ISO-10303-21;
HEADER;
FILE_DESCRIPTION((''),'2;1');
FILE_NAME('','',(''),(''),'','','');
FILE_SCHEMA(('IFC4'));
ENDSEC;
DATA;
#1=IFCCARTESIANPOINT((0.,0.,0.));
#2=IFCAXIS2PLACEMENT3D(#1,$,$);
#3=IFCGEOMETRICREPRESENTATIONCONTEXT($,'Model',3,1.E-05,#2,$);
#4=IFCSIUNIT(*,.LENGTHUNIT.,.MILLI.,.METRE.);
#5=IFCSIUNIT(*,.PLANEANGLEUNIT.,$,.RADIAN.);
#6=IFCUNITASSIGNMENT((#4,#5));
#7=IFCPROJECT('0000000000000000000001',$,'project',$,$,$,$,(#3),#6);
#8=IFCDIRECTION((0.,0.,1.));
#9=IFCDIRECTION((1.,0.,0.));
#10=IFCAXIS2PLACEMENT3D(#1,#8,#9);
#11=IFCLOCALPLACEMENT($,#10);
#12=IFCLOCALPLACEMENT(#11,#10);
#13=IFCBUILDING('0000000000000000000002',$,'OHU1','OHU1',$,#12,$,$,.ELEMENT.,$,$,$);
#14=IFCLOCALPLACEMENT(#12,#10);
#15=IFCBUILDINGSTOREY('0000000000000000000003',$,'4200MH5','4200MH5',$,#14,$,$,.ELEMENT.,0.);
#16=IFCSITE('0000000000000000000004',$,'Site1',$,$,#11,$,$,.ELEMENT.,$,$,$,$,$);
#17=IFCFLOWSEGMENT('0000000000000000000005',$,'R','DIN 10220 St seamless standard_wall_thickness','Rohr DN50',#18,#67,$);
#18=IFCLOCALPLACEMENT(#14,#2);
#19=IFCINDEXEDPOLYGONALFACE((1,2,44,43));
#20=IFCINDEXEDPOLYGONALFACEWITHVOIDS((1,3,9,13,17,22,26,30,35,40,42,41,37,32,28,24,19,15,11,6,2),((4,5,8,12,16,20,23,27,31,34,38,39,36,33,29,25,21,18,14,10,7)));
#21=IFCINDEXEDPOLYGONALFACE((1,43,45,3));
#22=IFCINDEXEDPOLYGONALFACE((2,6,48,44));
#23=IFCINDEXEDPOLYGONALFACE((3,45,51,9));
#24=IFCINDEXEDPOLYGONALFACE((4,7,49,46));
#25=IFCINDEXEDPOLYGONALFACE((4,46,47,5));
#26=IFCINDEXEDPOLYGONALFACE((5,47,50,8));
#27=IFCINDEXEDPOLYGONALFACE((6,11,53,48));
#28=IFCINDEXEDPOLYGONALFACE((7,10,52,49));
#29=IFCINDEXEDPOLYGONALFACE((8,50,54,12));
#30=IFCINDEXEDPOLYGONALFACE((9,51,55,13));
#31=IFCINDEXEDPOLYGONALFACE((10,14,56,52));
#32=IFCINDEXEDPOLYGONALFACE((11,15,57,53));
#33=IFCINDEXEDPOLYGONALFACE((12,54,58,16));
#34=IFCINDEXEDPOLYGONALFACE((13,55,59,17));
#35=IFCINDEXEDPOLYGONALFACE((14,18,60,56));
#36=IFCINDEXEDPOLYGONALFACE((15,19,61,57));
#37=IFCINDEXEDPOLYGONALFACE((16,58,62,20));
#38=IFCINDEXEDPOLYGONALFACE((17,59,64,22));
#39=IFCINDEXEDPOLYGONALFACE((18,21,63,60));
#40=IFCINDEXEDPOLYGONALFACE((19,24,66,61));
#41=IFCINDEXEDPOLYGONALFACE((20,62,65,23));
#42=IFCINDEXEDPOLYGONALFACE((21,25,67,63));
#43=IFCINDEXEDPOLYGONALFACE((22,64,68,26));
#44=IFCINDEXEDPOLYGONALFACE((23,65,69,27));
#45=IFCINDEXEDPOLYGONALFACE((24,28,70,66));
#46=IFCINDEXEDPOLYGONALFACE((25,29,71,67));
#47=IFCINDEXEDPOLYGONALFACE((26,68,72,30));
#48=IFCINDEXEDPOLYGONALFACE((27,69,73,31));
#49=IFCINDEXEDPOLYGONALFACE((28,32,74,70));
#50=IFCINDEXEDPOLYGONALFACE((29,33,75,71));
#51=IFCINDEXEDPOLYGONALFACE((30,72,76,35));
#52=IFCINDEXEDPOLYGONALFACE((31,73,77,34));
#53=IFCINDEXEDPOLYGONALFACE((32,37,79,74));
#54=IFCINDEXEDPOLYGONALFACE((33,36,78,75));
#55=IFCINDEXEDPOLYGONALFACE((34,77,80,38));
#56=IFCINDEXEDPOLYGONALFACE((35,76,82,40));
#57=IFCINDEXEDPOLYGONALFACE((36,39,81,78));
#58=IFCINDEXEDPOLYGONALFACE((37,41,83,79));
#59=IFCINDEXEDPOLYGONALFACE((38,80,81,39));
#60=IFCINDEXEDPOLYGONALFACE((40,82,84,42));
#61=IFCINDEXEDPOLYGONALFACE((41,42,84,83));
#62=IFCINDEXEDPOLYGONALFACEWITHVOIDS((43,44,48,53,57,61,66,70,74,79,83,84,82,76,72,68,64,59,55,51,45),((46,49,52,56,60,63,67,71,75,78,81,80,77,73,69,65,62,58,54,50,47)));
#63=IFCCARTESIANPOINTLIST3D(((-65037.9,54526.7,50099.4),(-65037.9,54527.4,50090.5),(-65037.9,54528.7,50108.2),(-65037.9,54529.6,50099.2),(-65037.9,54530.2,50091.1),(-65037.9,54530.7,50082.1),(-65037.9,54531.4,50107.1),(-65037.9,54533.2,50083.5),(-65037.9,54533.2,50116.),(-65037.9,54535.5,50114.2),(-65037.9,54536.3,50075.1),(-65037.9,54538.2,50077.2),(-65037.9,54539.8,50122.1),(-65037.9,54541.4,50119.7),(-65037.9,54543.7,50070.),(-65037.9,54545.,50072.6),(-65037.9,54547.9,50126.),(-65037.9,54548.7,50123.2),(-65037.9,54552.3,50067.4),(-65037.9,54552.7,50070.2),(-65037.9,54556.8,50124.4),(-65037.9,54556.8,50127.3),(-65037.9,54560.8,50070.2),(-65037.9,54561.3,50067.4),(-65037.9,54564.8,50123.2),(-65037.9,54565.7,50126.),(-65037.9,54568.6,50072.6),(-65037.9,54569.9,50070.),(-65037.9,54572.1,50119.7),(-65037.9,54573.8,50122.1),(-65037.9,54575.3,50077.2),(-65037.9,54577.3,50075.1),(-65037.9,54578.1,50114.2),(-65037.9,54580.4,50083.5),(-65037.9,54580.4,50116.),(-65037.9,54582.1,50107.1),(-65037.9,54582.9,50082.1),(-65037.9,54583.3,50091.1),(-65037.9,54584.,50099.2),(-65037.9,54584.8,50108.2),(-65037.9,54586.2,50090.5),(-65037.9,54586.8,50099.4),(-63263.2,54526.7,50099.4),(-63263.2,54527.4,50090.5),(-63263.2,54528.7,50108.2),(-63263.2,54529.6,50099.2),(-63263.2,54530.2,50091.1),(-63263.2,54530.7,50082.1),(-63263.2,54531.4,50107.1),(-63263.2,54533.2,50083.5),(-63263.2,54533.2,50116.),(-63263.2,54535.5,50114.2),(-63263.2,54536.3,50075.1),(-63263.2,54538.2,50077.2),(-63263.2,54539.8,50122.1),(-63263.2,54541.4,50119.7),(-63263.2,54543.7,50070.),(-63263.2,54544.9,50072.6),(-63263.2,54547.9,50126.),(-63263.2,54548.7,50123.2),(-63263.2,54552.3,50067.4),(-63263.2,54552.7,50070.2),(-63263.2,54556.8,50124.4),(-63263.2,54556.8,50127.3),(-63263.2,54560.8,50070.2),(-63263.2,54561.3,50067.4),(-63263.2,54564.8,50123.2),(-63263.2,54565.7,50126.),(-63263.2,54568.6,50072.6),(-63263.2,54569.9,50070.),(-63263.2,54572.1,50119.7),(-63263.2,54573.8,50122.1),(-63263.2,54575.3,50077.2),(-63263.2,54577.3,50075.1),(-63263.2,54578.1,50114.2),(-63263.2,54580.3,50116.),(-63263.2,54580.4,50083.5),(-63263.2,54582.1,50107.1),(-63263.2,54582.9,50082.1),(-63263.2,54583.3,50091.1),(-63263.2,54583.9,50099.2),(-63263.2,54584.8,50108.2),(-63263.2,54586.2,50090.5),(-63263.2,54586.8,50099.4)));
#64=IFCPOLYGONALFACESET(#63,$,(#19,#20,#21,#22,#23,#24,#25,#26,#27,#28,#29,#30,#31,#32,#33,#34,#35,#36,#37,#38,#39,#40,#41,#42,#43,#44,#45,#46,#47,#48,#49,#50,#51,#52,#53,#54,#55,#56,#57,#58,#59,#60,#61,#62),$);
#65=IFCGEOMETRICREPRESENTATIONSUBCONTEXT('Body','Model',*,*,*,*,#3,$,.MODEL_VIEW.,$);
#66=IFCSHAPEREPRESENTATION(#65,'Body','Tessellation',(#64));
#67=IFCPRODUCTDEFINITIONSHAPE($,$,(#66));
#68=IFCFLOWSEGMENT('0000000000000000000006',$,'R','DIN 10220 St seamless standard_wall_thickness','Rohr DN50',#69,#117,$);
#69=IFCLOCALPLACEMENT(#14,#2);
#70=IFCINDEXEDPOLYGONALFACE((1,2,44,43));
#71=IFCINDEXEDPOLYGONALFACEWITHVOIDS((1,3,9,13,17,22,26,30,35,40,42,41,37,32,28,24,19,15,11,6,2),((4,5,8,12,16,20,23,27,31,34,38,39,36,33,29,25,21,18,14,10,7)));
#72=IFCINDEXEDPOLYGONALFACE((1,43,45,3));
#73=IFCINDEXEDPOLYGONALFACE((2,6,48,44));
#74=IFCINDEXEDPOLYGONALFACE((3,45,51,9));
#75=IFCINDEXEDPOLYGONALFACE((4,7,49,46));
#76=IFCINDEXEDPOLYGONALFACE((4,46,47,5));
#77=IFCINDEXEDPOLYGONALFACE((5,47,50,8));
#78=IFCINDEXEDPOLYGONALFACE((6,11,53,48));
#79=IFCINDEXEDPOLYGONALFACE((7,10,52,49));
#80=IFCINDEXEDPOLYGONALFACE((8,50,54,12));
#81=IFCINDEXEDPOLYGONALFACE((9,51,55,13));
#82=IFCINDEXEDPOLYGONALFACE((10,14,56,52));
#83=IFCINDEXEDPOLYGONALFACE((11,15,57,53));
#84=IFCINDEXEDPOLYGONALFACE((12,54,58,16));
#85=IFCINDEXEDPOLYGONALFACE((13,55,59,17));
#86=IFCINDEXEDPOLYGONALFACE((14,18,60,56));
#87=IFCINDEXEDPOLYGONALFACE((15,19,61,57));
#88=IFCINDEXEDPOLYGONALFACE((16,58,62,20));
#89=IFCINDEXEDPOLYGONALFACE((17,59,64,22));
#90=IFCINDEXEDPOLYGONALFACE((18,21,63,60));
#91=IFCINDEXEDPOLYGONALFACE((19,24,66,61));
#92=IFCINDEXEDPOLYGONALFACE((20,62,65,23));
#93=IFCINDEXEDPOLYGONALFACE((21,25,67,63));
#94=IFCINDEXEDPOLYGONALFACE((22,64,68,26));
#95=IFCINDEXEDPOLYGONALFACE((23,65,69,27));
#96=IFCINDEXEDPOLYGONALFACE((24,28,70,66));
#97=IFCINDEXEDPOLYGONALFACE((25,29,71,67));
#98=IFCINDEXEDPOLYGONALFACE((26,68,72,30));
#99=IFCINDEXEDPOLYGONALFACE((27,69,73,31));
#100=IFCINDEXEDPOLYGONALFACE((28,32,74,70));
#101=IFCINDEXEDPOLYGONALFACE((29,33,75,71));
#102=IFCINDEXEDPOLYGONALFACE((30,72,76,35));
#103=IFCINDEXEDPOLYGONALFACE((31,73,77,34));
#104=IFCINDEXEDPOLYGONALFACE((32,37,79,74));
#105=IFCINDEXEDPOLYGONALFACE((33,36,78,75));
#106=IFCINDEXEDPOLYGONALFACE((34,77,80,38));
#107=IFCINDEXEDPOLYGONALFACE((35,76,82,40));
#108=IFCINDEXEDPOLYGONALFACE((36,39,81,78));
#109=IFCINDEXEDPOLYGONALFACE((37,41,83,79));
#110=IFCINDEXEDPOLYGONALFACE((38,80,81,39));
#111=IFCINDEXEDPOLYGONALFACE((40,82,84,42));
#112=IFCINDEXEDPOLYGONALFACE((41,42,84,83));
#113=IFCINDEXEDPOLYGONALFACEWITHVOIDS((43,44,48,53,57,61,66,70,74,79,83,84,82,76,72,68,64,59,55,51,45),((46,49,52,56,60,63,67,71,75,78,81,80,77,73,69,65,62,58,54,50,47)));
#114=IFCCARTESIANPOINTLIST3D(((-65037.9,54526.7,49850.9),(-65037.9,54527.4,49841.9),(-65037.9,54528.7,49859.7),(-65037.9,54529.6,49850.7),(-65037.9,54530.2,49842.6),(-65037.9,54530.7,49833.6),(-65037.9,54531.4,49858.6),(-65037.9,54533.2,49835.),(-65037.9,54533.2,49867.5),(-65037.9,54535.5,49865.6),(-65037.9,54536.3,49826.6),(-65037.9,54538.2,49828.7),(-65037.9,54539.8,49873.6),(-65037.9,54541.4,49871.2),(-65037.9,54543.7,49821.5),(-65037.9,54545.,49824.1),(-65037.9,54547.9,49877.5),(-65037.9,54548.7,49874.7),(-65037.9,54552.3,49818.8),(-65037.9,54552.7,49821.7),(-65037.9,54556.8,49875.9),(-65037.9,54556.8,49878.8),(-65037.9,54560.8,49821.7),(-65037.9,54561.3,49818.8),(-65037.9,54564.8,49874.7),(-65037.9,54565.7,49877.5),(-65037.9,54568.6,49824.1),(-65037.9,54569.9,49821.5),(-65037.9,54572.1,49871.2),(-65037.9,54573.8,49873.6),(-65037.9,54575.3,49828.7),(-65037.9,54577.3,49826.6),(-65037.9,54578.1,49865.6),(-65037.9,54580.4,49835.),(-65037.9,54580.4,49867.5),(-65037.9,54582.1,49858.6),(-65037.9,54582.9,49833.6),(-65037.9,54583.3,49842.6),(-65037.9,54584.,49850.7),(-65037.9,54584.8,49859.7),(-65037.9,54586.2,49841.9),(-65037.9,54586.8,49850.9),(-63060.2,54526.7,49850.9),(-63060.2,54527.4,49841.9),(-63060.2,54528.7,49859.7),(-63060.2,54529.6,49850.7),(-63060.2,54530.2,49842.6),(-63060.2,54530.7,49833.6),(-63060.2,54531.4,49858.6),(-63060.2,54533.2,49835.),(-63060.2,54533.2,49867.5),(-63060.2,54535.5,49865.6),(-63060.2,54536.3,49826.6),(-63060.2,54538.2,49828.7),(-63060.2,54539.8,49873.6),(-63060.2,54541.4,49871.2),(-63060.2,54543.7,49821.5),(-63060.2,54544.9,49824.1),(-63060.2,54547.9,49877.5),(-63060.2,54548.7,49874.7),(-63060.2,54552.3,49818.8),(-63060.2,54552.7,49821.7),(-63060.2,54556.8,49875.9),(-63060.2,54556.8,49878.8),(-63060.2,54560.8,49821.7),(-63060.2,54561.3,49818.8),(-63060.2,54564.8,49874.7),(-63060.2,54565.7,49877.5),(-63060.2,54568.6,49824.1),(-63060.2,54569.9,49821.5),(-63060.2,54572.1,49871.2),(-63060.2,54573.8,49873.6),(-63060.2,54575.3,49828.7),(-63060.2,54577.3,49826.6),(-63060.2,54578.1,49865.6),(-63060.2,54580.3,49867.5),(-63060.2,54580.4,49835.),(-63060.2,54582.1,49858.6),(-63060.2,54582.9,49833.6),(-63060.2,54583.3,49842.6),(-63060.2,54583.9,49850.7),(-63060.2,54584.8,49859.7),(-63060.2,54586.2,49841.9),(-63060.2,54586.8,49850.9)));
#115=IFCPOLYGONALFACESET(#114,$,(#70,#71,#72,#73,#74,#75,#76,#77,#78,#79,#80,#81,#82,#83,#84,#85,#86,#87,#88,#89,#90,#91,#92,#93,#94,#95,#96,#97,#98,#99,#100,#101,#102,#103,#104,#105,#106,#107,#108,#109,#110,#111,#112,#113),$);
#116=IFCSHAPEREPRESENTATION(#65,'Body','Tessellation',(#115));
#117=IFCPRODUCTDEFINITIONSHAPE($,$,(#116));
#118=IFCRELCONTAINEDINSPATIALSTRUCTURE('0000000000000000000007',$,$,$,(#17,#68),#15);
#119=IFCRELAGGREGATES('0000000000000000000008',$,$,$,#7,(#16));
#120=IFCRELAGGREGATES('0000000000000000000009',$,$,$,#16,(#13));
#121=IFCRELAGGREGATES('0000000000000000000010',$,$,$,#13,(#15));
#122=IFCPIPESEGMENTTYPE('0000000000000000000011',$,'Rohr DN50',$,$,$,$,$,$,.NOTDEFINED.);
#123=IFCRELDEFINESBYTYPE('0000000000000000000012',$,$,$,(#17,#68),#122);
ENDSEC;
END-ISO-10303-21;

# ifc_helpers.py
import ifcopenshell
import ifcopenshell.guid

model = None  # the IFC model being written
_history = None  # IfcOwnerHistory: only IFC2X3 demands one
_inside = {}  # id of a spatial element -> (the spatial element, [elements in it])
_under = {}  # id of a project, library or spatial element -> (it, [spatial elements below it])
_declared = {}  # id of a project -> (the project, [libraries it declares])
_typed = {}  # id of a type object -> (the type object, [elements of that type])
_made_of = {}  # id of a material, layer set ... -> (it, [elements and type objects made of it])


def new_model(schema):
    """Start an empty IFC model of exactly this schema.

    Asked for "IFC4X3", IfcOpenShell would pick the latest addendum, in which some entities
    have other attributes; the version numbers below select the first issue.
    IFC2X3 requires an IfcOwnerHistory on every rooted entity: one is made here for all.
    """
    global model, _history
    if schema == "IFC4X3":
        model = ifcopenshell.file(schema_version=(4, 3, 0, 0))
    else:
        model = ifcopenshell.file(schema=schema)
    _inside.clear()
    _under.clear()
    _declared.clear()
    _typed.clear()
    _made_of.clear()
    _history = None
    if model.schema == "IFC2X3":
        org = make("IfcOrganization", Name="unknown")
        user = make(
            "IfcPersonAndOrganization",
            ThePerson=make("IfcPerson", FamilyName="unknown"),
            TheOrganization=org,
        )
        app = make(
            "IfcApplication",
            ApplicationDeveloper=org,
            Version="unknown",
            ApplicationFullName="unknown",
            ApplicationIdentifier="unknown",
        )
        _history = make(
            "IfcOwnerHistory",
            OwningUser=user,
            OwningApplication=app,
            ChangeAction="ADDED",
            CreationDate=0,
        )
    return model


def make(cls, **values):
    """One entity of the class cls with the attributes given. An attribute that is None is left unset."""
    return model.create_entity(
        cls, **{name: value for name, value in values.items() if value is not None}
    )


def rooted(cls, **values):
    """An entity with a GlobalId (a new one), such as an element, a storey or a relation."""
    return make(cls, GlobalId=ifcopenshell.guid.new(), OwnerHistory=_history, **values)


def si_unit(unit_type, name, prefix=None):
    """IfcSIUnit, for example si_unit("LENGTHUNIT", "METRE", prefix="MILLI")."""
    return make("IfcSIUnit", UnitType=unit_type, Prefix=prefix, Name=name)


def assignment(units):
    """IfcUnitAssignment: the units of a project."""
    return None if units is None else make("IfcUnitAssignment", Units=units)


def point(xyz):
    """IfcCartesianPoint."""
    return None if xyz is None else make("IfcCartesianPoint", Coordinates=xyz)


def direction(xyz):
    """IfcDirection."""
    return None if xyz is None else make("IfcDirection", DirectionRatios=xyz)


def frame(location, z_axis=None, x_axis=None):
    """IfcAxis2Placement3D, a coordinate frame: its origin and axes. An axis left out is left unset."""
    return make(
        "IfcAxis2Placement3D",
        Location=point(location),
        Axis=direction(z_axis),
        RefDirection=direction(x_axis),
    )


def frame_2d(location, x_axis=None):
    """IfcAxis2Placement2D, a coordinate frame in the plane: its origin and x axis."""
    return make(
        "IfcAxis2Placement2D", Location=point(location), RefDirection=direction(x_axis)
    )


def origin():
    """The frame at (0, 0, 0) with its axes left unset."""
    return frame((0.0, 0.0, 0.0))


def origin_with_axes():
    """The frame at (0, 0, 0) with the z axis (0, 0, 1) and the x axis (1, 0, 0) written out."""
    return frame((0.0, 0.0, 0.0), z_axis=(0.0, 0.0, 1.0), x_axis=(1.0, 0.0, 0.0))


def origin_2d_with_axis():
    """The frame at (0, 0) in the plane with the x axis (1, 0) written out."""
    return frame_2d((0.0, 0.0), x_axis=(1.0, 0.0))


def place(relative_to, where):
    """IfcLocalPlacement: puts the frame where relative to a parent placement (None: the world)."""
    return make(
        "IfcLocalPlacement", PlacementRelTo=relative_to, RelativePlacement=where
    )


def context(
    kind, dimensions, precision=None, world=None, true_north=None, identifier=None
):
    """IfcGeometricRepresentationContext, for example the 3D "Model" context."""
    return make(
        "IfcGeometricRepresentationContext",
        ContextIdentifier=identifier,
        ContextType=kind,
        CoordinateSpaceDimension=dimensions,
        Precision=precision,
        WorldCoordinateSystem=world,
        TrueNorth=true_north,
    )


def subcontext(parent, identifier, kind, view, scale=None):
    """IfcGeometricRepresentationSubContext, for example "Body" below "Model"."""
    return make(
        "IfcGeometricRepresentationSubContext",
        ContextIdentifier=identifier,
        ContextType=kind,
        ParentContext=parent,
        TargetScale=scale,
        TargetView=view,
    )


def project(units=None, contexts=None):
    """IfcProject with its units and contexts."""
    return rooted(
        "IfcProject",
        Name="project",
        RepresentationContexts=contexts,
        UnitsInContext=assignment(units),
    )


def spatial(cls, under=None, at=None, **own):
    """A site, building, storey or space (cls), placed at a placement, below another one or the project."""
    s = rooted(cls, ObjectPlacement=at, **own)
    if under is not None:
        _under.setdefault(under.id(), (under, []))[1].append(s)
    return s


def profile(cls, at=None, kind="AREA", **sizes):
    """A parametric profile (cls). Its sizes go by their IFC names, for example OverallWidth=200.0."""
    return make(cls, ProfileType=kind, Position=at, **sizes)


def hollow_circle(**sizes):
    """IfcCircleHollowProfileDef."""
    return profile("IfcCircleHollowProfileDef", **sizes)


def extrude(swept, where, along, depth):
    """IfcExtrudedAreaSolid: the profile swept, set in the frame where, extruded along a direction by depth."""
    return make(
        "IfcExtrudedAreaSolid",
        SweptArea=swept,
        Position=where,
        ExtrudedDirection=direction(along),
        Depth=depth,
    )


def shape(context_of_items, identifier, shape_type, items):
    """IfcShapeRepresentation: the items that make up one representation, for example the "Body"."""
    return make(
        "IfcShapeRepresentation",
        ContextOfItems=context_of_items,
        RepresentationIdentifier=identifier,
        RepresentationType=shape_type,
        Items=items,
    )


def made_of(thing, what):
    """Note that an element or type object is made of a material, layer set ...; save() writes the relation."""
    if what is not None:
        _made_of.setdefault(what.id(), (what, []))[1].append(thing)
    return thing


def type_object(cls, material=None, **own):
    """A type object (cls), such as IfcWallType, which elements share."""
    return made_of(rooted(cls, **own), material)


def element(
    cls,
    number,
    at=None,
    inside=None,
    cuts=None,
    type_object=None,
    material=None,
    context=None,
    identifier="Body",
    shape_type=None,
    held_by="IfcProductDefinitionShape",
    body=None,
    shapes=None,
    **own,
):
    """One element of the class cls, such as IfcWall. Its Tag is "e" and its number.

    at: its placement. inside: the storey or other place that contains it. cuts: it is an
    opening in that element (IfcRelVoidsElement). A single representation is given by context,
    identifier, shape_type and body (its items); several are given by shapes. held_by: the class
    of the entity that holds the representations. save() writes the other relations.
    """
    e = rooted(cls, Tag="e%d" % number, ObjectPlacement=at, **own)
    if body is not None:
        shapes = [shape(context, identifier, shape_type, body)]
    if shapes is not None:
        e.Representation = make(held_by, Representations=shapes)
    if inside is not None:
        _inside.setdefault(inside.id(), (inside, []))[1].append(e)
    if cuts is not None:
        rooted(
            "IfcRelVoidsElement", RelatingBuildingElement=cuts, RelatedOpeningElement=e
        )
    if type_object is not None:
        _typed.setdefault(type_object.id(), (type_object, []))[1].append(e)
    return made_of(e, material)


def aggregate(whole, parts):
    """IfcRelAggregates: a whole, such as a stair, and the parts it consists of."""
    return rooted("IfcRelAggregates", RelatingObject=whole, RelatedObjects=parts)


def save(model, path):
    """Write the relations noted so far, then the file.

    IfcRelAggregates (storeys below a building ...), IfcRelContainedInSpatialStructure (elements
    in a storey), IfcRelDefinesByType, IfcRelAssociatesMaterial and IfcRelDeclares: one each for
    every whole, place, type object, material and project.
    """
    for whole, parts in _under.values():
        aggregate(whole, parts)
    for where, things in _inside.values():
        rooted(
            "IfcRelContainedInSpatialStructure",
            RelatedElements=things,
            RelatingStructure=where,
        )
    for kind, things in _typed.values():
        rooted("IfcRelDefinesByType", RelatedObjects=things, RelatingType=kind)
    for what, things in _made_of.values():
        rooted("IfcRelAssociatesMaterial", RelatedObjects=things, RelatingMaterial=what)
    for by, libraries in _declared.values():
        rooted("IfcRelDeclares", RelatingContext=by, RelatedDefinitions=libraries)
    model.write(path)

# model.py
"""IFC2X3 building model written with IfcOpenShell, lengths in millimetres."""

from ifc_helpers import new_model, si_unit, frame, origin, origin_with_axes, origin_2d_with_axis, place, context, subcontext, project, spatial, hollow_circle, extrude, type_object, element, save


model = new_model("IFC2X3")

# Units and contexts
model_context = context("Model", 3, precision=1e-05, world=origin())
body_context = subcontext(model_context, "Body", "Model", "MODEL_VIEW")
ifc_project = project(units=[si_unit("LENGTHUNIT", "METRE", prefix="MILLI"), si_unit("PLANEANGLEUNIT", "RADIAN")], contexts=[model_context])

# Site, building, storey
site_placement = place(None, origin_with_axes())
site = spatial("IfcSite", under=ifc_project, at=site_placement, Name="Site1", CompositionType="ELEMENT")
building_placement = place(site_placement, origin_with_axes())
building = spatial("IfcBuilding", under=site, at=building_placement, Name="OHU1", Description="OHU1", CompositionType="ELEMENT")
storey_placement = place(building_placement, origin_with_axes())
storey = spatial("IfcBuildingStorey", under=building, at=storey_placement, Name="4200MH5", Description="4200MH5", CompositionType="ELEMENT", Elevation=0.0)

# Flow segments
pipe_segment_type_1 = type_object("IfcPipeSegmentType", Name="Rohr DN50", PredefinedType="NOTDEFINED")
flow_segment_1_placement = place(storey_placement, frame((-64150.6, 54556.8, 50097.2), z_axis=(0.0, 0.0, 1.0), x_axis=(1.0, 0.0, 0.0)))
element("IfcFlowSegment", 1, at=flow_segment_1_placement, inside=storey, type_object=pipe_segment_type_1, Name="R", Description="DIN 10220 St seamless standard_wall_thickness", ObjectType="Rohr DN50", context=body_context, shape_type="SweptSolid", body=[
    extrude(hollow_circle(Radius=30.1, WallThickness=2.9, at=origin_2d_with_axis()), frame((887.4, 0.0, 0.0), z_axis=(-1.0, 0.000003, 0.0), x_axis=(0.0, 0.0, 1.0)), (0.0, 0.0, 1.0), 1774.8),
])
flow_segment_2_placement = place(storey_placement, frame((-64049.1, 54556.8, 49848.7), z_axis=(0.0, 0.0, 1.0), x_axis=(1.0, 0.0, 0.0)))
element("IfcFlowSegment", 2, at=flow_segment_2_placement, inside=storey, type_object=pipe_segment_type_1, Name="R", Description="DIN 10220 St seamless standard_wall_thickness", ObjectType="Rohr DN50", context=body_context, shape_type="SweptSolid", body=[
    extrude(hollow_circle(Radius=30.1, WallThickness=2.9, at=origin_2d_with_axis()), frame((988.9, 0.0, 0.0), z_axis=(-1.0, 0.000003, 0.0), x_axis=(0.0, 0.0, 1.0)), (0.0, 0.0, 1.0), 1977.7),
])

save(model, "model.ifc")
